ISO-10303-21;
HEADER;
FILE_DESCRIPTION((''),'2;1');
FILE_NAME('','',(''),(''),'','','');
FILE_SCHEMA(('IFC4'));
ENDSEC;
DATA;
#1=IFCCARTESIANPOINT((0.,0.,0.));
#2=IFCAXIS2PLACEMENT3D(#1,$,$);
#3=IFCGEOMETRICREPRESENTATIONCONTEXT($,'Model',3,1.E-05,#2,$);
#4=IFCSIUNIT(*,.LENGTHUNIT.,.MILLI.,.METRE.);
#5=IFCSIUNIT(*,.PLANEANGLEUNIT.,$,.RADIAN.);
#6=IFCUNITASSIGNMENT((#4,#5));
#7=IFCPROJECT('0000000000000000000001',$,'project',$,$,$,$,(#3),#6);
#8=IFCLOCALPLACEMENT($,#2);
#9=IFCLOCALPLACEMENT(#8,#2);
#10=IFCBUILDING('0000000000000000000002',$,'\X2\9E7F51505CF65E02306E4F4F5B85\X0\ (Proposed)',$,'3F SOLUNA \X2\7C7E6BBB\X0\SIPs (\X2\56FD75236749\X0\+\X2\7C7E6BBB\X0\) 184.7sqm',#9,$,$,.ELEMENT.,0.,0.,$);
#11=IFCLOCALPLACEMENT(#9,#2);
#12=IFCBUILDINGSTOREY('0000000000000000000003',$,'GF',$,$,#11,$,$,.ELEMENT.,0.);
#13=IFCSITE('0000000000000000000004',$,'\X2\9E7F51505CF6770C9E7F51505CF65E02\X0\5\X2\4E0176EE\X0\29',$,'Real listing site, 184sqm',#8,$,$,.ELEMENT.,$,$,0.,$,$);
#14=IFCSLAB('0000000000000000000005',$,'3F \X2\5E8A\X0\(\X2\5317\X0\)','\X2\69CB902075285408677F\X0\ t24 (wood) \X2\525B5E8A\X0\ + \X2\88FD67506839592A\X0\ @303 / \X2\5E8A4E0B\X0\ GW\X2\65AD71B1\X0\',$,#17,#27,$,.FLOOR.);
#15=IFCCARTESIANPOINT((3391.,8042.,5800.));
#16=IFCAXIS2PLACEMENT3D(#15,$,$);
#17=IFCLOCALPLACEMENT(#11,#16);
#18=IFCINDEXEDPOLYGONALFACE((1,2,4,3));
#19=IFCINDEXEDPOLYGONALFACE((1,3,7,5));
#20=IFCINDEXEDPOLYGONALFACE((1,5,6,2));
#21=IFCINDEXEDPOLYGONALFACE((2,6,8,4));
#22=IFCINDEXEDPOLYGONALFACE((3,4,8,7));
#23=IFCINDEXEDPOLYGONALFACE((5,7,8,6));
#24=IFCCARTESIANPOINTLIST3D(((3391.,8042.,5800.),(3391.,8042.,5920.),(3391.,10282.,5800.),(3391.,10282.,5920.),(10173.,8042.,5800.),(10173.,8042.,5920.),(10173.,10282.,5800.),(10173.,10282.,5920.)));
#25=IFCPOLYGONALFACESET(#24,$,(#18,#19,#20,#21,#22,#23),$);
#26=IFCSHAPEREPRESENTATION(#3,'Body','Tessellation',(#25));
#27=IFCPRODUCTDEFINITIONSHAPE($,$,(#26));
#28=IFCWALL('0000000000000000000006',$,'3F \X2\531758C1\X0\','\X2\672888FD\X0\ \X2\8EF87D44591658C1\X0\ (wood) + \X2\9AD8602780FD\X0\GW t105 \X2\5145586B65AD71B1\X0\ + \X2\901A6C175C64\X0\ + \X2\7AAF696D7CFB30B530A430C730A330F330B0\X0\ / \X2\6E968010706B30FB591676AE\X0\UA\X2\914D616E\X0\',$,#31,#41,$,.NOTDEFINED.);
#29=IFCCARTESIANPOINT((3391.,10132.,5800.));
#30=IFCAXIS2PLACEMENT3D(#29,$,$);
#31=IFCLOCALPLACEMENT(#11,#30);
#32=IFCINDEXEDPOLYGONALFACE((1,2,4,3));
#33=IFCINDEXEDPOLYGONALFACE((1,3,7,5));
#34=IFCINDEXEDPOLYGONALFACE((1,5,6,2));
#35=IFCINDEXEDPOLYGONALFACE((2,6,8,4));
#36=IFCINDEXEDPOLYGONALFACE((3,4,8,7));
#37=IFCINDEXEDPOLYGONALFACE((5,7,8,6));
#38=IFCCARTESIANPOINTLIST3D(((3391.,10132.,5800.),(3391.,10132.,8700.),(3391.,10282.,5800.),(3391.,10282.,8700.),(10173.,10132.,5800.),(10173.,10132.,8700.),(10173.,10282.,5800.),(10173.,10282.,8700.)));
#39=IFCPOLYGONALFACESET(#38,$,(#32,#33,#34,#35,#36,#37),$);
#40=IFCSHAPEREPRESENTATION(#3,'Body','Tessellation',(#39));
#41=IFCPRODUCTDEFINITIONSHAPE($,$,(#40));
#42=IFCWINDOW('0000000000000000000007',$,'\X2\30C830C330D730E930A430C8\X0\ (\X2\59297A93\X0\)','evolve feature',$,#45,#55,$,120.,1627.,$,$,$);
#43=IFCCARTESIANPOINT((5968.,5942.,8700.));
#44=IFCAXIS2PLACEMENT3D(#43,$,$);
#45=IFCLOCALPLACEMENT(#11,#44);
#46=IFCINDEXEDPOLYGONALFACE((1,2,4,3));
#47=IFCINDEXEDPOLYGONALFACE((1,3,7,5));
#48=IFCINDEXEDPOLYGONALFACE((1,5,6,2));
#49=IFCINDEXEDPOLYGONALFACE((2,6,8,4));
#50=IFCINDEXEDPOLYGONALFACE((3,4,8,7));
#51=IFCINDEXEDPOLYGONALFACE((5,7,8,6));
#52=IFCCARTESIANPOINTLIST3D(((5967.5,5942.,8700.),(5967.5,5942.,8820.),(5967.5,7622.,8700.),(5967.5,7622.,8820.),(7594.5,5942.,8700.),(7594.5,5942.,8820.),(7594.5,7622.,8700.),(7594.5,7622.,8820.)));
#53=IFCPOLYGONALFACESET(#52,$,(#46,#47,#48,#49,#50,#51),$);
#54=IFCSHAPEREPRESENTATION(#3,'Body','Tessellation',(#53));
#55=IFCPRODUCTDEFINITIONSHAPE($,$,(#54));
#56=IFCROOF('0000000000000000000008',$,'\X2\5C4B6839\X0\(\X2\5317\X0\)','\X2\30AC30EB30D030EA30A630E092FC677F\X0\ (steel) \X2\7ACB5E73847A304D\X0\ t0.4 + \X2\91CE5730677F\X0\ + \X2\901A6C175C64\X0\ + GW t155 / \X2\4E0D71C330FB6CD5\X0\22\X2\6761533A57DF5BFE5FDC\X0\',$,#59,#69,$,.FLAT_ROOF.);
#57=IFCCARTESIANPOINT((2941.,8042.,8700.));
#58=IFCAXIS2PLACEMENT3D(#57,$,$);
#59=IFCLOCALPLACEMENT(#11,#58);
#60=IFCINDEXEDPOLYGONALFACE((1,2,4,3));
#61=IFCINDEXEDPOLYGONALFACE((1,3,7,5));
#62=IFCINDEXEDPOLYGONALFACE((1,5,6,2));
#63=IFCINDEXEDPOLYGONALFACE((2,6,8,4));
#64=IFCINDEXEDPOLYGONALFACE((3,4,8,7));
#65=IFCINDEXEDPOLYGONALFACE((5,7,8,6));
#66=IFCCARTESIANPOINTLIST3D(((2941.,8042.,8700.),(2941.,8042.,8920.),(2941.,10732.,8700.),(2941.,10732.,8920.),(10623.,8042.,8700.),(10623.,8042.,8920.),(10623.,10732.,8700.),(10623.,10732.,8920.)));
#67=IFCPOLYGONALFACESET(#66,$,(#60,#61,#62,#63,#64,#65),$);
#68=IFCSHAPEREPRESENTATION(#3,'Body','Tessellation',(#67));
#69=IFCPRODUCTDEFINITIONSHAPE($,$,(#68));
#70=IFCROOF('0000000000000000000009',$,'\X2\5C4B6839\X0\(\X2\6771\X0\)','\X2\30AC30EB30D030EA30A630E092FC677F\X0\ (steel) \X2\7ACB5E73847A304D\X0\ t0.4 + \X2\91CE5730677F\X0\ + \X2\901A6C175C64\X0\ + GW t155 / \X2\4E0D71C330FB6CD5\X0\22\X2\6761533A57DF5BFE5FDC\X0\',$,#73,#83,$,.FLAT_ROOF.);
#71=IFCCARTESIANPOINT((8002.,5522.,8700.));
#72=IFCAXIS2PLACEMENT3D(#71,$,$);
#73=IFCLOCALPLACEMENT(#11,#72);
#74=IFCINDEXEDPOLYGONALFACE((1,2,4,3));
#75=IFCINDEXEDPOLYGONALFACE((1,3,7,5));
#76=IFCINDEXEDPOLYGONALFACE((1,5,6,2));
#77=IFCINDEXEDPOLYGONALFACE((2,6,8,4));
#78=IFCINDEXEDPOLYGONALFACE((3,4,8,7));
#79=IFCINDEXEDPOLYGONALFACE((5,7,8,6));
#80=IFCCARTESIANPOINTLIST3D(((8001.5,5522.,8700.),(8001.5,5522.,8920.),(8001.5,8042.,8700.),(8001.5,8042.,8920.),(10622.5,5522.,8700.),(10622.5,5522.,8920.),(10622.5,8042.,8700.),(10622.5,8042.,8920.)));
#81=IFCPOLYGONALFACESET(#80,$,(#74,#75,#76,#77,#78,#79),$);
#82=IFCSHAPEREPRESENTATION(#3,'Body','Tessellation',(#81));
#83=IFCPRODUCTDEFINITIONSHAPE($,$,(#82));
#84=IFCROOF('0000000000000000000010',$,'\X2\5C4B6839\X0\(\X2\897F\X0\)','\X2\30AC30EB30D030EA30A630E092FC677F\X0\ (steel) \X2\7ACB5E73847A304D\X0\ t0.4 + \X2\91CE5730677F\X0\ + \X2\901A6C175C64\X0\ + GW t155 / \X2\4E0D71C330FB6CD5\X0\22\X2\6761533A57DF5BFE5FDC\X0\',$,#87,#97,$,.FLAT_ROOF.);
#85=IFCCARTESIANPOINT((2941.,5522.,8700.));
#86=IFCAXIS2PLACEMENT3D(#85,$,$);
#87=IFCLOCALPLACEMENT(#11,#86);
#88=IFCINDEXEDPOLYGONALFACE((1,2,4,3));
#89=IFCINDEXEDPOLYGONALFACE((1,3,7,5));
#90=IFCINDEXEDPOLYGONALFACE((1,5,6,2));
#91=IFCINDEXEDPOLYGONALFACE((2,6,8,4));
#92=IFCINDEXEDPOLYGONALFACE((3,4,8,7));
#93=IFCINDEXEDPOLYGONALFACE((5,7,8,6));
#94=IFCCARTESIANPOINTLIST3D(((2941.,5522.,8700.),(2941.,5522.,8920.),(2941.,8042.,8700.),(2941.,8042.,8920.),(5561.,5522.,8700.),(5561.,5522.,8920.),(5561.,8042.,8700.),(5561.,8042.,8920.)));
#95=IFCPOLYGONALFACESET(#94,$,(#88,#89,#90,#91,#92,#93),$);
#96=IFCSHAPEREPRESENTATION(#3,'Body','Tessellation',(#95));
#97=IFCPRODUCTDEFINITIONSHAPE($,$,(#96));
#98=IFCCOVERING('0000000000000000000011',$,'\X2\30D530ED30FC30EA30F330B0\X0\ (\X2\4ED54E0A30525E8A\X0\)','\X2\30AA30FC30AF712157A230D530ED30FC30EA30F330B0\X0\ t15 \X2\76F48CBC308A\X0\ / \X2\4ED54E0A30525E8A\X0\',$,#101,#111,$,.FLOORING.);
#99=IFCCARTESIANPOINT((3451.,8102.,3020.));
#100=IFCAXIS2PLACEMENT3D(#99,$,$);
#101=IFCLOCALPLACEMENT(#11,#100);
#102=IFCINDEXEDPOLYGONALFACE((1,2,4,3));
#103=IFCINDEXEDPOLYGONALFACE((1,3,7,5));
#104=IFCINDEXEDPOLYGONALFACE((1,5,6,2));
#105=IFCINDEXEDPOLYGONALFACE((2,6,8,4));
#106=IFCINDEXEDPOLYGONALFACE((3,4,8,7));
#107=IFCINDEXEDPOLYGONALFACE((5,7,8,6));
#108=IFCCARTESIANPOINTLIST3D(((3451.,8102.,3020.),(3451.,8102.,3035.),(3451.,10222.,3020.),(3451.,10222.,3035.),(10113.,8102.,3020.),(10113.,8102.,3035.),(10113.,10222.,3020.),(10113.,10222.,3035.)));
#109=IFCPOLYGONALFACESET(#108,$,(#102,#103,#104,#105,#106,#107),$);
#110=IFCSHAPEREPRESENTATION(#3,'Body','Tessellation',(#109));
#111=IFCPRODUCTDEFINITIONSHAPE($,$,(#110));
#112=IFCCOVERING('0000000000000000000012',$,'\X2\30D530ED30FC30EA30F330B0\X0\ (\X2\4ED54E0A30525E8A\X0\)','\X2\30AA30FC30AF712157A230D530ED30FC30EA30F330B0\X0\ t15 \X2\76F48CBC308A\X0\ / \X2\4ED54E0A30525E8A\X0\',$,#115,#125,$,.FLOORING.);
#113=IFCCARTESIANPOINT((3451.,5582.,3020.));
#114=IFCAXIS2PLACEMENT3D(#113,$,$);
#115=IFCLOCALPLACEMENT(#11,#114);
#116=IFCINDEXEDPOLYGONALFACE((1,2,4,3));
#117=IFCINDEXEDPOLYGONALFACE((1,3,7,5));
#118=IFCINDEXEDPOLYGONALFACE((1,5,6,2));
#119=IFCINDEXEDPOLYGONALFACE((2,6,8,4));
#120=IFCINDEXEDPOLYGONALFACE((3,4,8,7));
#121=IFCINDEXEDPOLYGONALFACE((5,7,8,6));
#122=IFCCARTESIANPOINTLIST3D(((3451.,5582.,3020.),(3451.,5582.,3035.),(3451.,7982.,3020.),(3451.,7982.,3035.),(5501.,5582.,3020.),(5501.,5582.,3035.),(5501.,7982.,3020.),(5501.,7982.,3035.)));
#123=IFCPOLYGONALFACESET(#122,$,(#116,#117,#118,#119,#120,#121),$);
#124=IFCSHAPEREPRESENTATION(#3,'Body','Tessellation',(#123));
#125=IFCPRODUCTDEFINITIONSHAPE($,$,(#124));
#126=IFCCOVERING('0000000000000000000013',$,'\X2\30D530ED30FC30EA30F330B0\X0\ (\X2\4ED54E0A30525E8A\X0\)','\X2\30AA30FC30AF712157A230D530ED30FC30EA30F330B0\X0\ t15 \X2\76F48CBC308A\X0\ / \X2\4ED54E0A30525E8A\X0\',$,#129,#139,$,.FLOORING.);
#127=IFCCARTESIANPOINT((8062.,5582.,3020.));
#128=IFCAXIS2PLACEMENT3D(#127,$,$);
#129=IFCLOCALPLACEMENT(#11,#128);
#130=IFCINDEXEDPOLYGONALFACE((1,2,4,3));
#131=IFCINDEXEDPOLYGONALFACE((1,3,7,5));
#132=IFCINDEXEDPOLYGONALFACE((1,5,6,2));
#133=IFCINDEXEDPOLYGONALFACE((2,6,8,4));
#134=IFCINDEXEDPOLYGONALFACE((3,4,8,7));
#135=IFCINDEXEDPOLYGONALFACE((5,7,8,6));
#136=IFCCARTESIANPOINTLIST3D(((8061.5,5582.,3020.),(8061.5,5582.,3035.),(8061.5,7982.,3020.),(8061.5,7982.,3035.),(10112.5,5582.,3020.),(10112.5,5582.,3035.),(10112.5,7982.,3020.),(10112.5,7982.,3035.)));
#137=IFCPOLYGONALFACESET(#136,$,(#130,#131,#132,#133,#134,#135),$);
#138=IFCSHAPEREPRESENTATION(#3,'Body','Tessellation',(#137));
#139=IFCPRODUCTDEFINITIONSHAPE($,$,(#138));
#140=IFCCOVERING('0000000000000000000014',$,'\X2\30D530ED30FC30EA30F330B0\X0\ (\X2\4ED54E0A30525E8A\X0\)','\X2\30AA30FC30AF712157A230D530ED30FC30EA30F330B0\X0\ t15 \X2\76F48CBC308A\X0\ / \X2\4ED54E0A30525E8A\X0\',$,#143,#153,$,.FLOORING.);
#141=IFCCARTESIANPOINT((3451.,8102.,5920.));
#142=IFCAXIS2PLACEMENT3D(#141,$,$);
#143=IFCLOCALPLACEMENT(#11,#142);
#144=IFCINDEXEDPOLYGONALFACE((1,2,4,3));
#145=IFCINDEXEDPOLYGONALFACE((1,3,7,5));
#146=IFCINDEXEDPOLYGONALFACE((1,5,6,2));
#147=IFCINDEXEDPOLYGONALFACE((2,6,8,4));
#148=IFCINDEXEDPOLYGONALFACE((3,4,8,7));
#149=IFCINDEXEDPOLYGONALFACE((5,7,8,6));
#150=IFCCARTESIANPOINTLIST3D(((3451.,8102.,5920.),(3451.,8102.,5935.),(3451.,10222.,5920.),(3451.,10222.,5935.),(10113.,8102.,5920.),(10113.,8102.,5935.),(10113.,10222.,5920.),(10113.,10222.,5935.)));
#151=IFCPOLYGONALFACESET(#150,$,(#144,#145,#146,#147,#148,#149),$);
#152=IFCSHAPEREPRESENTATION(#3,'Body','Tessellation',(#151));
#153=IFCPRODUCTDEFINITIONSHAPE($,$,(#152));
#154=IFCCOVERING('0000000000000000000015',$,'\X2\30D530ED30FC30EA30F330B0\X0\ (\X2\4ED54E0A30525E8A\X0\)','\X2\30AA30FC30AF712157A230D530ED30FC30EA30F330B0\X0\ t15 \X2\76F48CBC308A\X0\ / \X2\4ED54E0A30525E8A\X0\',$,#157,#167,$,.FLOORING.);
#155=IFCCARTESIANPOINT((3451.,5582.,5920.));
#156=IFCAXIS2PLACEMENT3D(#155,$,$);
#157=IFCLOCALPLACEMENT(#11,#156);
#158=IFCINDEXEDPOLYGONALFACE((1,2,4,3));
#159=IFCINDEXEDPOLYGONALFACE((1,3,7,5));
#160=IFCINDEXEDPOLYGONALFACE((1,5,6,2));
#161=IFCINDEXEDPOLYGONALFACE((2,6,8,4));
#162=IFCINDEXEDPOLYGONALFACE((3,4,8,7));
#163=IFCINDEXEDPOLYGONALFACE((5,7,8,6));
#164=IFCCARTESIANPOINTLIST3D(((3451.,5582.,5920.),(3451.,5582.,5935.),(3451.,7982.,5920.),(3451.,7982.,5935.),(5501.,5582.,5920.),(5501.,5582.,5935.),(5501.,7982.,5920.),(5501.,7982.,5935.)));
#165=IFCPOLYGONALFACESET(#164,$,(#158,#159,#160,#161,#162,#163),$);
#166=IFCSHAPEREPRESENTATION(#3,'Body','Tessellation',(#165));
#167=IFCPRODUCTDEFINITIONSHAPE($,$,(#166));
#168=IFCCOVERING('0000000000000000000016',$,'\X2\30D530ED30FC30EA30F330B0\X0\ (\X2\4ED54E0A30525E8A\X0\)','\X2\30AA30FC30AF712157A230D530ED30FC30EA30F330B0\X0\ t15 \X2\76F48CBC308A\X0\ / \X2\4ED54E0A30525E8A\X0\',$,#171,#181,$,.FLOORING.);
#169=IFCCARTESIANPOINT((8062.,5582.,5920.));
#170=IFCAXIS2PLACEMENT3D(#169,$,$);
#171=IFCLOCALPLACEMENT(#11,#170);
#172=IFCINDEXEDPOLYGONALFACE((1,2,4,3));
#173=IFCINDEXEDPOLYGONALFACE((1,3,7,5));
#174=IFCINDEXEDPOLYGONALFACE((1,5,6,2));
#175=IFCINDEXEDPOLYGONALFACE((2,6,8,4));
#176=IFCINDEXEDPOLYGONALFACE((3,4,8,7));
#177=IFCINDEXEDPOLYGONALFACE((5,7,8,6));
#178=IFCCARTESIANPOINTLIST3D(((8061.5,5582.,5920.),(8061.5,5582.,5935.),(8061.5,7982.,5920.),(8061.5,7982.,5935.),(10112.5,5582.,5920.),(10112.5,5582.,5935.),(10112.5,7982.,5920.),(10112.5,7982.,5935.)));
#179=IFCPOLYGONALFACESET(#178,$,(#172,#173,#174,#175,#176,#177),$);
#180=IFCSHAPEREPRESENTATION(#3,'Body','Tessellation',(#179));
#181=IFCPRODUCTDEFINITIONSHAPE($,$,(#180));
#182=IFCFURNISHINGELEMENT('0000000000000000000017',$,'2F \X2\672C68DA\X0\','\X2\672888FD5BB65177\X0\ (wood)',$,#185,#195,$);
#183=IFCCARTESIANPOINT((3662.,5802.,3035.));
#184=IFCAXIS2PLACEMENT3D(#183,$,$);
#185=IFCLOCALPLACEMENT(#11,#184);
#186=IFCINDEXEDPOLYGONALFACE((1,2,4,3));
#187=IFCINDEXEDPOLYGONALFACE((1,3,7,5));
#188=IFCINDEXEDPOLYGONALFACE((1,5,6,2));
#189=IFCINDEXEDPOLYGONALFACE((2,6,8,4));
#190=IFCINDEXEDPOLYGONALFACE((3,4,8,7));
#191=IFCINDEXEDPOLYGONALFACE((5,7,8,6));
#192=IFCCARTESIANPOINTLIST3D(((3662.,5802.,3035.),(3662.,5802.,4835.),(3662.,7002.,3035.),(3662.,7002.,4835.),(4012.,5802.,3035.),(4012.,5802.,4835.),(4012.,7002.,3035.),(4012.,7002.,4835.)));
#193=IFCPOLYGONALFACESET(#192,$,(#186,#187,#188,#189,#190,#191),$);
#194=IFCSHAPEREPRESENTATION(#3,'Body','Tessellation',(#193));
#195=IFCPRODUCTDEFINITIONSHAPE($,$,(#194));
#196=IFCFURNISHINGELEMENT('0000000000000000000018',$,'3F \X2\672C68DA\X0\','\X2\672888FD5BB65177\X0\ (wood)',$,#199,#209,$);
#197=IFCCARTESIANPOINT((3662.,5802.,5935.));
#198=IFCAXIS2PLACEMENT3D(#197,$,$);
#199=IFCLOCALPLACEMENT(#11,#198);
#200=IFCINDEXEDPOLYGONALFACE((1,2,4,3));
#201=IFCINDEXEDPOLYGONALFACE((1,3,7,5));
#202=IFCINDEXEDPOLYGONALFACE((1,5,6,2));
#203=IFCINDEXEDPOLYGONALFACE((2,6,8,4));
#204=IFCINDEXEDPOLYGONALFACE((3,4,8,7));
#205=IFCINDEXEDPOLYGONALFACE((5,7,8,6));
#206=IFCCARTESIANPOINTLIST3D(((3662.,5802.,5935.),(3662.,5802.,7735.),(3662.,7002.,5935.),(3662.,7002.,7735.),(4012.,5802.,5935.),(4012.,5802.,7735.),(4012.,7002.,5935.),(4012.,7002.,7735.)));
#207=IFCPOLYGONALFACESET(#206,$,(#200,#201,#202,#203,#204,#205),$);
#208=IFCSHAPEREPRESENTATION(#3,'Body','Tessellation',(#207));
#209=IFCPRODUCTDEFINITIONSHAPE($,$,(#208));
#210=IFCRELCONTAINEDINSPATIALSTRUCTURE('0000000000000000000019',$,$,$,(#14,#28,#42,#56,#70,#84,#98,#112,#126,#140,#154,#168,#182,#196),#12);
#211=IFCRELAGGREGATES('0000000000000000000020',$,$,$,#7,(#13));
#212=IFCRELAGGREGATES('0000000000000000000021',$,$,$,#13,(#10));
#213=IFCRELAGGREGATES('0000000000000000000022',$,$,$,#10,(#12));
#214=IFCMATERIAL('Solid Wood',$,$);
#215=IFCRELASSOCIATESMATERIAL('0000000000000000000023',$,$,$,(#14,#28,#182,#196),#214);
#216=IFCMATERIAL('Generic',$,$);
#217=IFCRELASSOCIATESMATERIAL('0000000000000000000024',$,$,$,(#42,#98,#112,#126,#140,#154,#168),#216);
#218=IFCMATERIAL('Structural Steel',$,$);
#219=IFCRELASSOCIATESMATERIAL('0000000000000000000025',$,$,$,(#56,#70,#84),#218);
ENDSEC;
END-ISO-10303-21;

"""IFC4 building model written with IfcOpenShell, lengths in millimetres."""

from ifc_helpers import new_model, si_unit, frame, frame_2d, origin, place, context, project, spatial, rectangle, extrude, material, element, save


model = new_model("IFC4")

# Units and contexts
model_context = context("Model", 3, precision=1e-05, world=origin())
ifc_project = project(units=[si_unit("LENGTHUNIT", "METRE", prefix="MILLI"), si_unit("PLANEANGLEUNIT", "RADIAN")], contexts=[model_context])

# Site, building, storey
site_placement = place(None, origin())
site = spatial("IfcSite", under=ifc_project, at=site_placement, Name="鹿児島県鹿児島市5丁目29", ObjectType="Real listing site, 184sqm", CompositionType="ELEMENT", RefElevation=0.0)
building_placement = place(site_placement, origin())
building = spatial("IfcBuilding", under=site, at=building_placement, Name="鹿児島市の住宅 (Proposed)", ObjectType="3F SOLUNA 籾殻SIPs (国産杉+籾殻) 184.7sqm", CompositionType="ELEMENT", ElevationOfRefHeight=0.0, ElevationOfTerrain=0.0)
storey_placement = place(building_placement, origin())
storey = spatial("IfcBuildingStorey", under=building, at=storey_placement, Name="GF", CompositionType="ELEMENT", Elevation=0.0)

# Slab
ifc_material_1 = material(Name="Solid Wood")
slab_placement = place(storey_placement, frame((3391.0, 8042.0, 5800.0)))
element("IfcSlab", 1, at=slab_placement, inside=storey, material=ifc_material_1, Name="3F 床(北)", Description="構造用合板 t24 (wood) 剛床 + 製材根太 @303 / 床下 GW断熱", PredefinedType="FLOOR", context=model_context, shape_type="SweptSolid", body=[
    extrude(rectangle(XDim=6782.0, YDim=2240.0, at=frame_2d((3391.0, 1120.0))), frame((3391.0, 8042.0, 5800.0)), (0.0, 0.0, 1.0), 120.0),
])

# Wall
wall_1_placement = place(storey_placement, frame((3391.0, 10132.0, 5800.0)))
element("IfcWall", 2, at=wall_1_placement, inside=storey, material=ifc_material_1, Name="3F 北壁", Description="木製 軸組外壁 (wood) + 高性能GW t105 充填断熱 + 通気層 + 窯業系サイディング / 準耐火・外皮UA配慮", PredefinedType="NOTDEFINED", context=model_context, shape_type="SweptSolid", body=[
    extrude(rectangle(XDim=6782.0, YDim=150.0, at=frame_2d((3391.0, 75.0))), frame((3391.0, 10132.0, 5800.0)), (0.0, 0.0, 1.0), 2900.0),
])

# Window
ifc_material_2 = material(Name="Generic")
window_1_placement = place(storey_placement, frame((5968.0, 5942.0, 8700.0)))
element("IfcWindow", 3, at=window_1_placement, inside=storey, material=ifc_material_2, Name="トップライト (天窓)", Description="evolve feature", OverallHeight=120.0, OverallWidth=1627.0, context=model_context, shape_type="SweptSolid", body=[
    extrude(rectangle(XDim=1627.0, YDim=1680.0, at=frame_2d((813.0, 840.0))), frame((5968.0, 5942.0, 8700.0)), (0.0, 0.0, 1.0), 120.0),
])

# Roofs
ifc_material_3 = material(Name="Structural Steel")
roof_1_placement = place(storey_placement, frame((2941.0, 8042.0, 8700.0)))
element("IfcRoof", 4, at=roof_1_placement, inside=storey, material=ifc_material_3, Name="屋根(北)", Description="ガルバリウム鋼板 (steel) 立平葺き t0.4 + 野地板 + 通気層 + GW t155 / 不燃・法22条区域対応", PredefinedType="FLAT_ROOF", context=model_context, shape_type="SweptSolid", body=[
    extrude(rectangle(XDim=7682.0, YDim=2690.0, at=frame_2d((3841.0, 1345.0))), frame((2941.0, 8042.0, 8700.0)), (0.0, 0.0, 1.0), 220.0),
])
roof_2_placement = place(storey_placement, frame((8002.0, 5522.0, 8700.0)))
element("IfcRoof", 5, at=roof_2_placement, inside=storey, material=ifc_material_3, Name="屋根(東)", Description="ガルバリウム鋼板 (steel) 立平葺き t0.4 + 野地板 + 通気層 + GW t155 / 不燃・法22条区域対応", PredefinedType="FLAT_ROOF", context=model_context, shape_type="SweptSolid", body=[
    extrude(rectangle(XDim=2621.0, YDim=2520.0, at=frame_2d((1310.0, 1260.0))), frame((8002.0, 5522.0, 8700.0)), (0.0, 0.0, 1.0), 220.0),
])
roof_3_placement = place(storey_placement, frame((2941.0, 5522.0, 8700.0)))
element("IfcRoof", 6, at=roof_3_placement, inside=storey, material=ifc_material_3, Name="屋根(西)", Description="ガルバリウム鋼板 (steel) 立平葺き t0.4 + 野地板 + 通気層 + GW t155 / 不燃・法22条区域対応", PredefinedType="FLAT_ROOF", context=model_context, shape_type="SweptSolid", body=[
    extrude(rectangle(XDim=2620.0, YDim=2520.0, at=frame_2d((1310.0, 1260.0))), frame((2941.0, 5522.0, 8700.0)), (0.0, 0.0, 1.0), 220.0),
])

# Coverings
covering_1_placement = place(storey_placement, frame((3451.0, 8102.0, 3020.0)))
element("IfcCovering", 7, at=covering_1_placement, inside=storey, material=ifc_material_2, Name="フローリング (仕上げ床)", Description="オーク無垢フローリング t15 直貼り / 仕上げ床", PredefinedType="FLOORING", context=model_context, shape_type="SweptSolid", body=[
    extrude(rectangle(XDim=6662.0, YDim=2120.0, at=frame_2d((3331.0, 1060.0))), frame((3451.0, 8102.0, 3020.0)), (0.0, 0.0, 1.0), 15.0),
])
covering_2_placement = place(storey_placement, frame((3451.0, 5582.0, 3020.0)))
element("IfcCovering", 8, at=covering_2_placement, inside=storey, material=ifc_material_2, Name="フローリング (仕上げ床)", Description="オーク無垢フローリング t15 直貼り / 仕上げ床", PredefinedType="FLOORING", context=model_context, shape_type="SweptSolid", body=[
    extrude(rectangle(XDim=2050.0, YDim=2400.0, at=frame_2d((1025.0, 1200.0))), frame((3451.0, 5582.0, 3020.0)), (0.0, 0.0, 1.0), 15.0),
])
covering_3_placement = place(storey_placement, frame((8062.0, 5582.0, 3020.0)))
element("IfcCovering", 9, at=covering_3_placement, inside=storey, material=ifc_material_2, Name="フローリング (仕上げ床)", Description="オーク無垢フローリング t15 直貼り / 仕上げ床", PredefinedType="FLOORING", context=model_context, shape_type="SweptSolid", body=[
    extrude(rectangle(XDim=2051.0, YDim=2400.0, at=frame_2d((1025.0, 1200.0))), frame((8062.0, 5582.0, 3020.0)), (0.0, 0.0, 1.0), 15.0),
])
covering_4_placement = place(storey_placement, frame((3451.0, 8102.0, 5920.0)))
element("IfcCovering", 10, at=covering_4_placement, inside=storey, material=ifc_material_2, Name="フローリング (仕上げ床)", Description="オーク無垢フローリング t15 直貼り / 仕上げ床", PredefinedType="FLOORING", context=model_context, shape_type="SweptSolid", body=[
    extrude(rectangle(XDim=6662.0, YDim=2120.0, at=frame_2d((3331.0, 1060.0))), frame((3451.0, 8102.0, 5920.0)), (0.0, 0.0, 1.0), 15.0),
])
covering_5_placement = place(storey_placement, frame((3451.0, 5582.0, 5920.0)))
element("IfcCovering", 11, at=covering_5_placement, inside=storey, material=ifc_material_2, Name="フローリング (仕上げ床)", Description="オーク無垢フローリング t15 直貼り / 仕上げ床", PredefinedType="FLOORING", context=model_context, shape_type="SweptSolid", body=[
    extrude(rectangle(XDim=2050.0, YDim=2400.0, at=frame_2d((1025.0, 1200.0))), frame((3451.0, 5582.0, 5920.0)), (0.0, 0.0, 1.0), 15.0),
])
covering_6_placement = place(storey_placement, frame((8062.0, 5582.0, 5920.0)))
element("IfcCovering", 12, at=covering_6_placement, inside=storey, material=ifc_material_2, Name="フローリング (仕上げ床)", Description="オーク無垢フローリング t15 直貼り / 仕上げ床", PredefinedType="FLOORING", context=model_context, shape_type="SweptSolid", body=[
    extrude(rectangle(XDim=2051.0, YDim=2400.0, at=frame_2d((1025.0, 1200.0))), frame((8062.0, 5582.0, 5920.0)), (0.0, 0.0, 1.0), 15.0),
])

# Furnishing elements
furnishing_1_placement = place(storey_placement, frame((3662.0, 5802.0, 3035.0)))
element("IfcFurnishingElement", 13, at=furnishing_1_placement, inside=storey, material=ifc_material_1, Name="2F 本棚", Description="木製家具 (wood)", context=model_context, shape_type="SweptSolid", body=[
    extrude(rectangle(XDim=350.0, YDim=1200.0, at=frame_2d((175.0, 600.0))), frame((3662.0, 5802.0, 3035.0)), (0.0, 0.0, 1.0), 1800.0),
])
furnishing_2_placement = place(storey_placement, frame((3662.0, 5802.0, 5935.0)))
element("IfcFurnishingElement", 14, at=furnishing_2_placement, inside=storey, material=ifc_material_1, Name="3F 本棚", Description="木製家具 (wood)", context=model_context, shape_type="SweptSolid", body=[
    extrude(rectangle(XDim=350.0, YDim=1200.0, at=frame_2d((175.0, 600.0))), frame((3662.0, 5802.0, 5935.0)), (0.0, 0.0, 1.0), 1800.0),
])

save(model, "model.ifc")
